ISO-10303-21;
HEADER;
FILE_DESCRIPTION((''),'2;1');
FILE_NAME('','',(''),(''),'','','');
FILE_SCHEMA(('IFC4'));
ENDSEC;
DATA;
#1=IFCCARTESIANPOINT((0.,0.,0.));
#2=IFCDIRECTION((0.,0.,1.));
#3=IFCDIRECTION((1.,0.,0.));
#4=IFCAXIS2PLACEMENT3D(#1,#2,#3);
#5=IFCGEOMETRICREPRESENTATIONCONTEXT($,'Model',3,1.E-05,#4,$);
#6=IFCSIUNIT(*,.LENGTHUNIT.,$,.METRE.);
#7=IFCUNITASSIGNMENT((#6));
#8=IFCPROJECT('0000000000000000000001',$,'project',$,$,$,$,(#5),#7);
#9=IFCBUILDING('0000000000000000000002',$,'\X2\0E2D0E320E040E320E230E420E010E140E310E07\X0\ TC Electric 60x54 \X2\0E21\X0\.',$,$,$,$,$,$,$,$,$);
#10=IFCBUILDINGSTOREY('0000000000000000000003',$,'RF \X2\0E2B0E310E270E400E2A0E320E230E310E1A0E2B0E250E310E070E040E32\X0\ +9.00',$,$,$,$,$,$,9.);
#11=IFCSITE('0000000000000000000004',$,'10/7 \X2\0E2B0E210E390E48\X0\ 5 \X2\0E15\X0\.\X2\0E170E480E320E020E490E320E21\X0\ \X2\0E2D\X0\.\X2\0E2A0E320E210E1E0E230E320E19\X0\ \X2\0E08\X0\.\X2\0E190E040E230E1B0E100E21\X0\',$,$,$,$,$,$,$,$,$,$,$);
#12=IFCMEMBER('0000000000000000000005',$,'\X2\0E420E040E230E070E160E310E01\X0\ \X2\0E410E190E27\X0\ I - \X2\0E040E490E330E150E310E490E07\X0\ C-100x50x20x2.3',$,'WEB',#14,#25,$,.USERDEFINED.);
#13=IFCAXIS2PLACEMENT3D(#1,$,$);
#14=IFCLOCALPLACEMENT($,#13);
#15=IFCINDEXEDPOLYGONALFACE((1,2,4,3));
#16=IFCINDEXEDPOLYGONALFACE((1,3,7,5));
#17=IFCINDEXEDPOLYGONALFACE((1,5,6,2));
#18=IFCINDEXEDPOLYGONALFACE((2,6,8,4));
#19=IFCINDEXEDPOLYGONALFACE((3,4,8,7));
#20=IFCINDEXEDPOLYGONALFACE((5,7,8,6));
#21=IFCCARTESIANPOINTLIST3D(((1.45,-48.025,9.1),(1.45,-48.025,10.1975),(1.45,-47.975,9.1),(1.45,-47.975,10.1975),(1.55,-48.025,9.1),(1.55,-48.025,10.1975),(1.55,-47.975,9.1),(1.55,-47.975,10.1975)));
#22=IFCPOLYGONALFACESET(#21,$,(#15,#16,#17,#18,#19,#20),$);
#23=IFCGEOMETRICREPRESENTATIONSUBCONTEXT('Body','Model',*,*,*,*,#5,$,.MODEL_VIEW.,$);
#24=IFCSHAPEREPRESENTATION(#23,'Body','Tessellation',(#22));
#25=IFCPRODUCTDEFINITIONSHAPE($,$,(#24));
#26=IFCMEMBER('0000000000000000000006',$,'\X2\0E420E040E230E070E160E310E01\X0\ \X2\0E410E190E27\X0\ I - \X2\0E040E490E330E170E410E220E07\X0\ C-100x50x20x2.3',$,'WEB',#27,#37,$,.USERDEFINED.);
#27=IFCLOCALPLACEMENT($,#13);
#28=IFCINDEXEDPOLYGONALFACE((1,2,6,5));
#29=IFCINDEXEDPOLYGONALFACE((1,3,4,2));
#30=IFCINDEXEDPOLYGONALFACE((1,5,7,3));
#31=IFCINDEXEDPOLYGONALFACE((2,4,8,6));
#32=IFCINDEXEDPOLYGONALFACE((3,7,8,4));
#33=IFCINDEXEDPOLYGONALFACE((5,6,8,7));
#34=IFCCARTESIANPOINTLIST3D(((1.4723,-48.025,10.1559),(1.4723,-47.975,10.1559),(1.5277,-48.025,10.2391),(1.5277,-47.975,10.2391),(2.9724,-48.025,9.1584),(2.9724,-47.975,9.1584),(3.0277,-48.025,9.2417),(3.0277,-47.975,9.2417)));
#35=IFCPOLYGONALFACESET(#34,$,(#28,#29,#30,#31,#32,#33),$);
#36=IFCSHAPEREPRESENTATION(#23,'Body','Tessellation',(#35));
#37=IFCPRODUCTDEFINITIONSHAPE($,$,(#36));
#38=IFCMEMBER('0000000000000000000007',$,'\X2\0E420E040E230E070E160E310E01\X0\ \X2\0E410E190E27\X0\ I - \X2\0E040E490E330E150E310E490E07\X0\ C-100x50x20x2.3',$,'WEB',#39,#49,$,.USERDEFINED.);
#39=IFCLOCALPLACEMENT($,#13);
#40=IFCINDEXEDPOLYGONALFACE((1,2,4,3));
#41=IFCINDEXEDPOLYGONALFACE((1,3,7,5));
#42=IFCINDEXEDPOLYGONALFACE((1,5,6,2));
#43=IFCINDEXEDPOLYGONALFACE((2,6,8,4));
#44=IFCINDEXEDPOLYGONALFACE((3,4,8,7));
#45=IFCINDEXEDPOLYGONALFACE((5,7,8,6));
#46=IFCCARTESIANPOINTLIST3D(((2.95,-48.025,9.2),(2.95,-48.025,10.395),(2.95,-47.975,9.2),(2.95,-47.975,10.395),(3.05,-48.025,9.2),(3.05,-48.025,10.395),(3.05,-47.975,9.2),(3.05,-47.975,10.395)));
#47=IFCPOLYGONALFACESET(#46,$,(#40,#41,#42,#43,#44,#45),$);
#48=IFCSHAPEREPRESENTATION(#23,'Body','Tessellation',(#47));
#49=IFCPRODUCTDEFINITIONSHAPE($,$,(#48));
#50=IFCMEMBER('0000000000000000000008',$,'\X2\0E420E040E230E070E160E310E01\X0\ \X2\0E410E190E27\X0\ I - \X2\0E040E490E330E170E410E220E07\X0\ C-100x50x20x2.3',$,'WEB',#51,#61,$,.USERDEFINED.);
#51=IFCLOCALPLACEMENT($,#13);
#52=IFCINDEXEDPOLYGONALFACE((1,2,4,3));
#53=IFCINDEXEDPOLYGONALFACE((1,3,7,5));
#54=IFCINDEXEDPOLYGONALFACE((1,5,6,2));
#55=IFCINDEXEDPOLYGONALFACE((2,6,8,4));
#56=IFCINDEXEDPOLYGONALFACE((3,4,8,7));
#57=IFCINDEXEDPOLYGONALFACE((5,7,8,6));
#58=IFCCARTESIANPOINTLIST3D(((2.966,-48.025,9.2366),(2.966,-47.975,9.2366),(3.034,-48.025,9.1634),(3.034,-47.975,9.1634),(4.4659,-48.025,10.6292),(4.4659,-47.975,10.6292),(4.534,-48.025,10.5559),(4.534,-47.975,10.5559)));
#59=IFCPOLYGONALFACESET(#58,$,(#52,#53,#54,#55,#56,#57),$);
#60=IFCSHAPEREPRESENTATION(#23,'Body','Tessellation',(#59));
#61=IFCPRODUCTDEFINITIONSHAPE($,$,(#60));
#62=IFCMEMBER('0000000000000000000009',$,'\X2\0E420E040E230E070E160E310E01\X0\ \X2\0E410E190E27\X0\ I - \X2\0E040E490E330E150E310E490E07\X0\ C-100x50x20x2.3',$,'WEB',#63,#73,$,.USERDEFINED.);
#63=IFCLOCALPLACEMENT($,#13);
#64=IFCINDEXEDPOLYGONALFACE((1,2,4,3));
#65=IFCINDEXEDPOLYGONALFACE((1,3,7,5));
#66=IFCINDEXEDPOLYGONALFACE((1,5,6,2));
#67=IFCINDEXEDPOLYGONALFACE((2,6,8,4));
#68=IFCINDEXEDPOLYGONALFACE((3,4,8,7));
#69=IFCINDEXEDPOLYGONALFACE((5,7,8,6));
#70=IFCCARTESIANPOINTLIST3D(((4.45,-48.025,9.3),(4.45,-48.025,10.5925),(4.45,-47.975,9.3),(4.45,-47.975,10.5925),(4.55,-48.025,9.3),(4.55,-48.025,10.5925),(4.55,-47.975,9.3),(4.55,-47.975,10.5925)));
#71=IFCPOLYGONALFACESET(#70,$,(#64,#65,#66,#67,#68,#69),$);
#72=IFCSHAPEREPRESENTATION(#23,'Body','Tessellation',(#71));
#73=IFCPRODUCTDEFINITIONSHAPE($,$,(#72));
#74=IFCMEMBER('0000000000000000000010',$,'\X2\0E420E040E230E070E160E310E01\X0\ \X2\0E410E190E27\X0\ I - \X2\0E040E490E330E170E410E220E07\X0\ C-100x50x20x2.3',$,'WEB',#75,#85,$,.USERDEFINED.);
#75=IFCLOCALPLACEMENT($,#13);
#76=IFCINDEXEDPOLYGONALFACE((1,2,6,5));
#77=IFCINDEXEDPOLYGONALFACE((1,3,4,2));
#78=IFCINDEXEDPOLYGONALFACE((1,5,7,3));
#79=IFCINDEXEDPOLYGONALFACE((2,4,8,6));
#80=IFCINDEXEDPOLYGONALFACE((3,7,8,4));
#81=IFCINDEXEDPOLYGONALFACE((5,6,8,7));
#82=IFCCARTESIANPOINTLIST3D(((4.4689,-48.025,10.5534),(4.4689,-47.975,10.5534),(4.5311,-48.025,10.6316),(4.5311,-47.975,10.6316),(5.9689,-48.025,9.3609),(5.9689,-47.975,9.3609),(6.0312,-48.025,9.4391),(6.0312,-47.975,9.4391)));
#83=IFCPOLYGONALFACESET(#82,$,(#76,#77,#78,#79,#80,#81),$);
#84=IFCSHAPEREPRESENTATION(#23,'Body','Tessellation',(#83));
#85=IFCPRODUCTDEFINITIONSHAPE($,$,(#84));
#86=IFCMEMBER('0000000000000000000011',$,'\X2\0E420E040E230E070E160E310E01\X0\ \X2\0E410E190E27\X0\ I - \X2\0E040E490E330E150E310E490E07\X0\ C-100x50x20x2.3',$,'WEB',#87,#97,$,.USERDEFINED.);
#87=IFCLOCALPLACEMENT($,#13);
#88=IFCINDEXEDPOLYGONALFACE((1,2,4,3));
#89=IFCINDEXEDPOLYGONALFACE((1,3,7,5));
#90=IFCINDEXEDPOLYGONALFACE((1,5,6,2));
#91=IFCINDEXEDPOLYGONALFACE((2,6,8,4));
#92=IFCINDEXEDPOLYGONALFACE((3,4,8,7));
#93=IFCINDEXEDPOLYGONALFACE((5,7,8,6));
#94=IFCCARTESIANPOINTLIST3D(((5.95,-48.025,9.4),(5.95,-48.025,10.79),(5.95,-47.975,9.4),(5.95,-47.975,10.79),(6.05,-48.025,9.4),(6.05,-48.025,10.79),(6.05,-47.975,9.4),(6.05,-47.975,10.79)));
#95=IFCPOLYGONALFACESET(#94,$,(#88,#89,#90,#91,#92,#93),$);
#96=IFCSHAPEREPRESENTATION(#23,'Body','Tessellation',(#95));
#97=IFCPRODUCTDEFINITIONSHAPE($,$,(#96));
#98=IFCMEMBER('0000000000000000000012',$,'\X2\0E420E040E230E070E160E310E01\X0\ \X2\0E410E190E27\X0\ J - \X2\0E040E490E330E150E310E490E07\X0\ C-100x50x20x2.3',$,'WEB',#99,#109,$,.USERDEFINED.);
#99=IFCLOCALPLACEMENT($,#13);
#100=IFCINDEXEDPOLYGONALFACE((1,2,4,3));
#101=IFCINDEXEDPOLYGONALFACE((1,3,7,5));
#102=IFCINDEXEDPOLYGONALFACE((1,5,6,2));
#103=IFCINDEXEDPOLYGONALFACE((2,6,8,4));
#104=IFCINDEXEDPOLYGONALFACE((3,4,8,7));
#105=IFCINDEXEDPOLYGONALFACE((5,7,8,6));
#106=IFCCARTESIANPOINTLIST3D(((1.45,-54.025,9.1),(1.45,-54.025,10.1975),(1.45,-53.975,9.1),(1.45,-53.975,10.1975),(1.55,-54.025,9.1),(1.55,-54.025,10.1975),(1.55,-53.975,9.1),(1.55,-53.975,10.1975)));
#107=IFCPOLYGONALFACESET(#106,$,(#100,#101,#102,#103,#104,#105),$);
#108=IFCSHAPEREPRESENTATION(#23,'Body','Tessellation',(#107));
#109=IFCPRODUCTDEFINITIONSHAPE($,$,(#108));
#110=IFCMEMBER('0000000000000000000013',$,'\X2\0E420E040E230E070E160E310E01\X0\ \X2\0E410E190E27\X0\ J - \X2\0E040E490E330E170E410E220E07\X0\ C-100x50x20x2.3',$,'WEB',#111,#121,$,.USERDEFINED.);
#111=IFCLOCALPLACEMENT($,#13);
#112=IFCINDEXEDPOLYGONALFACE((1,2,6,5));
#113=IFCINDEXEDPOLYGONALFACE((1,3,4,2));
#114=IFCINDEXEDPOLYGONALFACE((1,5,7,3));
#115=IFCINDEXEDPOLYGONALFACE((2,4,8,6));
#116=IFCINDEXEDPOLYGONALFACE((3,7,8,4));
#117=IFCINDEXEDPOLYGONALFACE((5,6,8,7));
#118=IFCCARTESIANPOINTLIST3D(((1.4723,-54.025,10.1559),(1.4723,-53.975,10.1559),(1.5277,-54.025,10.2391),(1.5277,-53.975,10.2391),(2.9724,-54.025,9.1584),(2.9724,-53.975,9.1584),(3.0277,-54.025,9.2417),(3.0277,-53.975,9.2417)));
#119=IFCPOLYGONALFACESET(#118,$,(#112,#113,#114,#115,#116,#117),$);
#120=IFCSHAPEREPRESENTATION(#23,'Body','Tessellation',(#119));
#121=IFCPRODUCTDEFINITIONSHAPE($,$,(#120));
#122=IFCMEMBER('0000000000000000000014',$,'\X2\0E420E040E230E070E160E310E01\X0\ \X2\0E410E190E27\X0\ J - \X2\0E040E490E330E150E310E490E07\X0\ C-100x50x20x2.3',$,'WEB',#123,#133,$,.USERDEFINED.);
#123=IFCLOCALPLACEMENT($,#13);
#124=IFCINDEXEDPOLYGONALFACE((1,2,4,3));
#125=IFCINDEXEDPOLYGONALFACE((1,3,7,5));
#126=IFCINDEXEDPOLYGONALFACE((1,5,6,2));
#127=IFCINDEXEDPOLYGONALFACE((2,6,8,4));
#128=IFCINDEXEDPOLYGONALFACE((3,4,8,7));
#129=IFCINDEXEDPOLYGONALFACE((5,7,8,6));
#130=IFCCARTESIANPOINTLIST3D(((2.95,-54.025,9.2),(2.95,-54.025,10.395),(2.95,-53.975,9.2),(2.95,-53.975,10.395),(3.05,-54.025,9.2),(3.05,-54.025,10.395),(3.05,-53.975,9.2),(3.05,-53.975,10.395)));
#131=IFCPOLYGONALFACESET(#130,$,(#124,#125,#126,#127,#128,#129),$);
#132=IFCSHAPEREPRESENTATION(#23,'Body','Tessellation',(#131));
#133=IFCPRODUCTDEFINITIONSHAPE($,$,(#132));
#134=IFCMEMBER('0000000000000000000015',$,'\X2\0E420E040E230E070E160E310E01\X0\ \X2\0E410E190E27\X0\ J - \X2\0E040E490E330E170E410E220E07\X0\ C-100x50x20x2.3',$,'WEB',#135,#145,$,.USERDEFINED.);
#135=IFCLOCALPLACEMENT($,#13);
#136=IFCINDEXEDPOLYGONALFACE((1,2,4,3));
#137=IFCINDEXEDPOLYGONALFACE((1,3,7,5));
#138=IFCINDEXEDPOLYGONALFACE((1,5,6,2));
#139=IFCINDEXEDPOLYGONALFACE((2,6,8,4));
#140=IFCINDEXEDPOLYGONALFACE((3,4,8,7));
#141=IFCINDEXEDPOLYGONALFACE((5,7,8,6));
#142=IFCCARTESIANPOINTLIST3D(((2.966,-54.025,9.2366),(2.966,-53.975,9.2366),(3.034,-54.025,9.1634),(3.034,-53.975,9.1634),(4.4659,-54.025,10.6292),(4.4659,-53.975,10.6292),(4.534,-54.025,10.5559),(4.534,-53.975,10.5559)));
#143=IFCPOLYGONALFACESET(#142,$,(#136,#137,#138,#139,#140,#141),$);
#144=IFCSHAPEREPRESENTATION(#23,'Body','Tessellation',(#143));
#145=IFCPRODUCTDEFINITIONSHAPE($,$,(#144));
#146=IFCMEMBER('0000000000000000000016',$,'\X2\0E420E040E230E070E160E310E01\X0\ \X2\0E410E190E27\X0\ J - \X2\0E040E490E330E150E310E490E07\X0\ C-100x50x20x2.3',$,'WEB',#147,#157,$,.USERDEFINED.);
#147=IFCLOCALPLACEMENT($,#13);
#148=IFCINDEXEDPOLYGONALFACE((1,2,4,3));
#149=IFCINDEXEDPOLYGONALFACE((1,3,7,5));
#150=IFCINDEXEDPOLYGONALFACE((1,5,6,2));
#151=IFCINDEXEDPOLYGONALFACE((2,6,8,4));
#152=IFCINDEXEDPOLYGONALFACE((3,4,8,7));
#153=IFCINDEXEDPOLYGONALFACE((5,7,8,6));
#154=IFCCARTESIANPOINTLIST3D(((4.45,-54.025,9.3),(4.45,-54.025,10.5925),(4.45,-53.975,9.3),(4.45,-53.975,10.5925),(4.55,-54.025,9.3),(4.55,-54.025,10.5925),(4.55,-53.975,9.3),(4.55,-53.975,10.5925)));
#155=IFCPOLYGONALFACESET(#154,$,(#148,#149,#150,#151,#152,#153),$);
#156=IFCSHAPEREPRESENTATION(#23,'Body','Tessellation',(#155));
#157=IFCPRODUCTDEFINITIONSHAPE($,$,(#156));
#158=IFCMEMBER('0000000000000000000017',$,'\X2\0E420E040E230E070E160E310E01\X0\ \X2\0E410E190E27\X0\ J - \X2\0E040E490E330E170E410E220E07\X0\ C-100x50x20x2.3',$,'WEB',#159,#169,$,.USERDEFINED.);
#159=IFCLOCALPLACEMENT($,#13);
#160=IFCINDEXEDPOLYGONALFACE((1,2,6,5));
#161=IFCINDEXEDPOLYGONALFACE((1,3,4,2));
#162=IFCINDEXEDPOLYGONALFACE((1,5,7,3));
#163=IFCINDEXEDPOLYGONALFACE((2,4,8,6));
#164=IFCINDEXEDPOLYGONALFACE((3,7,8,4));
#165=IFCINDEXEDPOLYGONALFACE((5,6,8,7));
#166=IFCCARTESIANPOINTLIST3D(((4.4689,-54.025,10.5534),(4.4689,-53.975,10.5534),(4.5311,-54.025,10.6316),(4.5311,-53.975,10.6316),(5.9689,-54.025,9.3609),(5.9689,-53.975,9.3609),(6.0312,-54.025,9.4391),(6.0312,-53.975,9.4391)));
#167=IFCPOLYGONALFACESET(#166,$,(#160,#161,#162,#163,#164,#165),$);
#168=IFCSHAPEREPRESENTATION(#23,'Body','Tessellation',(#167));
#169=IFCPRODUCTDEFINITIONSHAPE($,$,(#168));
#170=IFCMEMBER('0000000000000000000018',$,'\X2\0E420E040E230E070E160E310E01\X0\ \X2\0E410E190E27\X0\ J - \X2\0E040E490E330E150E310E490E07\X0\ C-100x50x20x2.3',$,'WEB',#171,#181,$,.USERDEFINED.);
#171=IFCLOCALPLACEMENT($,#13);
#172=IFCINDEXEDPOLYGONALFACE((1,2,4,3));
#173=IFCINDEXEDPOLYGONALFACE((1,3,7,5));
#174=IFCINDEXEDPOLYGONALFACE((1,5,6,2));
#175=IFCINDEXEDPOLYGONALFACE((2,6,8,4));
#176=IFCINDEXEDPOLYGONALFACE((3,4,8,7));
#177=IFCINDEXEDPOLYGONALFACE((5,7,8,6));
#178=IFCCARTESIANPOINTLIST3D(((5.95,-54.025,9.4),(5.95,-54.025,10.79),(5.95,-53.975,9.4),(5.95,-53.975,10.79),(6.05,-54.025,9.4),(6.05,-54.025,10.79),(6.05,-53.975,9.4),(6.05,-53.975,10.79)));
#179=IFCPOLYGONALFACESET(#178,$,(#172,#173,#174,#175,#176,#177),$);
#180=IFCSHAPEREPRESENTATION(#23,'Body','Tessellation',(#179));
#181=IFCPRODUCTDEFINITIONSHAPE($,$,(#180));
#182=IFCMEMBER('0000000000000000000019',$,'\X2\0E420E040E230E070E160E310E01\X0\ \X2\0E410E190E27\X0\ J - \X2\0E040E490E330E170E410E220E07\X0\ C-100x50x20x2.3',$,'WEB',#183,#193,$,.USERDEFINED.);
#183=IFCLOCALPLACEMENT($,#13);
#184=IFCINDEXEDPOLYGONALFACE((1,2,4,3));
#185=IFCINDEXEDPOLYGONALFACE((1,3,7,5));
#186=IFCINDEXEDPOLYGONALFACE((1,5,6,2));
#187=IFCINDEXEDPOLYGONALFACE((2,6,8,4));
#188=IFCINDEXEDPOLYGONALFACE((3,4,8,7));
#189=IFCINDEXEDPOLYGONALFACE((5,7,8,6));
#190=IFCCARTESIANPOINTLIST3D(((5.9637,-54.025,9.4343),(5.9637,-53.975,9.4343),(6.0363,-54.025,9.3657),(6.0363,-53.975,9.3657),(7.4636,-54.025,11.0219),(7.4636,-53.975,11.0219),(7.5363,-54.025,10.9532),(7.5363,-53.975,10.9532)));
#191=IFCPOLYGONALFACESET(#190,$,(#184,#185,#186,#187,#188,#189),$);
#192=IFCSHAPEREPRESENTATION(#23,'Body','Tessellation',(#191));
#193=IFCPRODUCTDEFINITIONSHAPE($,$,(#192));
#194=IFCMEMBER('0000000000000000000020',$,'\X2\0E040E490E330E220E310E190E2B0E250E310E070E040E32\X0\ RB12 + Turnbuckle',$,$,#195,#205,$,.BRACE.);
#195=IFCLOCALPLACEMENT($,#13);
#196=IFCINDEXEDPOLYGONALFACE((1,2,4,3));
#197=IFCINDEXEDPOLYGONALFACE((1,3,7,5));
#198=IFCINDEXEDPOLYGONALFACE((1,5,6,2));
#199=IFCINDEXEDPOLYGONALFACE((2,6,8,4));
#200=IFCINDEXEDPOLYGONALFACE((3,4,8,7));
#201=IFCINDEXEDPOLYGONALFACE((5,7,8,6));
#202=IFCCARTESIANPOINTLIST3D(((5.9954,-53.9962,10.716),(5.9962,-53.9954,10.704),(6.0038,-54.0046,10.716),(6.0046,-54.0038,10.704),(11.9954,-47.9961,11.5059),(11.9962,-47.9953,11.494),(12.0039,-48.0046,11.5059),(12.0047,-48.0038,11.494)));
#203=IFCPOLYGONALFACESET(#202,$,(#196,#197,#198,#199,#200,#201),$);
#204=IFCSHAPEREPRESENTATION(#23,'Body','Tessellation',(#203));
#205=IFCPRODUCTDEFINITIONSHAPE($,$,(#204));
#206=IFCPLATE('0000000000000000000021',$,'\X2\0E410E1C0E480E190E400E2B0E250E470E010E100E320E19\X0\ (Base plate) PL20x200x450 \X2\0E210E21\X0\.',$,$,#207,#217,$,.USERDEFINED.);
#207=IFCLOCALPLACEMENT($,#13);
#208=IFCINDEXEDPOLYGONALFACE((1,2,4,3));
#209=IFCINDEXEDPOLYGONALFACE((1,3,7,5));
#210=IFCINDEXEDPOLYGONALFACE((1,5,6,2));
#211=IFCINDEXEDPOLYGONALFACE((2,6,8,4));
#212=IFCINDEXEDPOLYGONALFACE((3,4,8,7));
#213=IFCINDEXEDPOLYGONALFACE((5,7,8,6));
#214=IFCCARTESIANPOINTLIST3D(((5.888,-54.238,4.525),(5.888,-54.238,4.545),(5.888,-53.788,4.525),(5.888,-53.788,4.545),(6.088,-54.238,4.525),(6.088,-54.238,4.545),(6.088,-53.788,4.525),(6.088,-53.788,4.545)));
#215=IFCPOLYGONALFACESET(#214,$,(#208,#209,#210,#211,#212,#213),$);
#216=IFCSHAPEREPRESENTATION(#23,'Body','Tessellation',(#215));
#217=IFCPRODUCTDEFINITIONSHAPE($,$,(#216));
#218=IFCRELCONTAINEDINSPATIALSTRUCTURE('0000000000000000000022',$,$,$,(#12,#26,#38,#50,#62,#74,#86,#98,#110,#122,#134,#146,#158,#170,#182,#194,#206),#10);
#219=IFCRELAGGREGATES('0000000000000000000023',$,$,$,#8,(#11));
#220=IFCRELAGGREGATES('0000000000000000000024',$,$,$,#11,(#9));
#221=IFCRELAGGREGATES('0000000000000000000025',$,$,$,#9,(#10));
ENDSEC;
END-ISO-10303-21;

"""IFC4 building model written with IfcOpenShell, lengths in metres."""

from ifc_helpers import new_model, si_unit, frame, origin, origin_with_axes, origin_2d, place, context, subcontext, project, spatial, rectangle, extrude, element, save


model = new_model("IFC4")

# Units and contexts
model_context = context("Model", 3, precision=1e-05, world=origin_with_axes())
body_context = subcontext(model_context, "Body", "Model", "MODEL_VIEW")
ifc_project = project(units=[si_unit("LENGTHUNIT", "METRE")], contexts=[model_context])

# Site, building, storey
site = spatial("IfcSite", under=ifc_project, Name="10/7 หมู่ 5 ต.ท่าข้าม อ.สามพราน จ.นครปฐม")
building = spatial("IfcBuilding", under=site, Name="อาคารโกดัง TC Electric 60x54 ม.")
storey = spatial("IfcBuildingStorey", under=building, Name="RF หัวเสารับหลังคา +9.00", Elevation=9.0)

# Members
member_1_placement = place(None, frame((1.5, -48.0, 9.1), z_axis=(0.0, 0.0, 1.0), x_axis=(0.0, 1.0, 0.0)))
element("IfcMember", 1, at=member_1_placement, inside=storey, Name="โครงถัก แนว I - ค้ำตั้ง C-100x50x20x2.3", ObjectType="WEB", PredefinedType="USERDEFINED", context=body_context, shape_type="SweptSolid", body=[
    extrude(rectangle(XDim=0.05, YDim=0.1, at=origin_2d()), origin(), (0.0, 0.0, 1.0), 1.0975),
])
member_2_placement = place(None, frame((1.5, -48.0, 10.1975), z_axis=(0.8327, 0.0, -0.5537), x_axis=(0.0, -1.0, 0.0)))
element("IfcMember", 2, at=member_2_placement, inside=storey, Name="โครงถัก แนว I - ค้ำทแยง C-100x50x20x2.3", ObjectType="WEB", PredefinedType="USERDEFINED", context=body_context, shape_type="SweptSolid", body=[
    extrude(rectangle(XDim=0.05, YDim=0.1, at=origin_2d()), origin(), (0.0, 0.0, 1.0), 1.8014),
])
member_3_placement = place(None, frame((3.0, -48.0, 9.2), z_axis=(0.0, 0.0, 1.0), x_axis=(0.0, 1.0, 0.0)))
element("IfcMember", 3, at=member_3_placement, inside=storey, Name="โครงถัก แนว I - ค้ำตั้ง C-100x50x20x2.3", ObjectType="WEB", PredefinedType="USERDEFINED", context=body_context, shape_type="SweptSolid", body=[
    extrude(rectangle(XDim=0.05, YDim=0.1, at=origin_2d()), origin(), (0.0, 0.0, 1.0), 1.195),
])
member_4_placement = place(None, frame((3.0, -48.0, 9.2), z_axis=(0.7329, 0.0, 0.6804), x_axis=(0.0, -1.0, 0.0)))
element("IfcMember", 4, at=member_4_placement, inside=storey, Name="โครงถัก แนว I - ค้ำทแยง C-100x50x20x2.3", ObjectType="WEB", PredefinedType="USERDEFINED", context=body_context, shape_type="SweptSolid", body=[
    extrude(rectangle(XDim=0.05, YDim=0.1, at=origin_2d()), origin(), (0.0, 0.0, 1.0), 2.0467),
])
member_5_placement = place(None, frame((4.5, -48.0, 9.3), z_axis=(0.0, 0.0, 1.0), x_axis=(0.0, 1.0, 0.0)))
element("IfcMember", 5, at=member_5_placement, inside=storey, Name="โครงถัก แนว I - ค้ำตั้ง C-100x50x20x2.3", ObjectType="WEB", PredefinedType="USERDEFINED", context=body_context, shape_type="SweptSolid", body=[
    extrude(rectangle(XDim=0.05, YDim=0.1, at=origin_2d()), origin(), (0.0, 0.0, 1.0), 1.2925),
])
member_6_placement = place(None, frame((4.5, -48.0, 10.5925), z_axis=(0.7828, 0.0, -0.6223), x_axis=(0.0, -1.0, 0.0)))
element("IfcMember", 6, at=member_6_placement, inside=storey, Name="โครงถัก แนว I - ค้ำทแยง C-100x50x20x2.3", ObjectType="WEB", PredefinedType="USERDEFINED", context=body_context, shape_type="SweptSolid", body=[
    extrude(rectangle(XDim=0.05, YDim=0.1, at=origin_2d()), origin(), (0.0, 0.0, 1.0), 1.9163),
])
member_7_placement = place(None, frame((6.0, -48.0, 9.4), z_axis=(0.0, 0.0, 1.0), x_axis=(0.0, 1.0, 0.0)))
element("IfcMember", 7, at=member_7_placement, inside=storey, Name="โครงถัก แนว I - ค้ำตั้ง C-100x50x20x2.3", ObjectType="WEB", PredefinedType="USERDEFINED", context=body_context, shape_type="SweptSolid", body=[
    extrude(rectangle(XDim=0.05, YDim=0.1, at=origin_2d()), origin(), (0.0, 0.0, 1.0), 1.39),
])
member_8_placement = place(None, frame((1.5, -54.0, 9.1), z_axis=(0.0, 0.0, 1.0), x_axis=(0.0, 1.0, 0.0)))
element("IfcMember", 8, at=member_8_placement, inside=storey, Name="โครงถัก แนว J - ค้ำตั้ง C-100x50x20x2.3", ObjectType="WEB", PredefinedType="USERDEFINED", context=body_context, shape_type="SweptSolid", body=[
    extrude(rectangle(XDim=0.05, YDim=0.1, at=origin_2d()), origin(), (0.0, 0.0, 1.0), 1.0975),
])
member_9_placement = place(None, frame((1.5, -54.0, 10.1975), z_axis=(0.8327, 0.0, -0.5537), x_axis=(0.0, -1.0, 0.0)))
element("IfcMember", 9, at=member_9_placement, inside=storey, Name="โครงถัก แนว J - ค้ำทแยง C-100x50x20x2.3", ObjectType="WEB", PredefinedType="USERDEFINED", context=body_context, shape_type="SweptSolid", body=[
    extrude(rectangle(XDim=0.05, YDim=0.1, at=origin_2d()), origin(), (0.0, 0.0, 1.0), 1.8014),
])
member_10_placement = place(None, frame((3.0, -54.0, 9.2), z_axis=(0.0, 0.0, 1.0), x_axis=(0.0, 1.0, 0.0)))
element("IfcMember", 10, at=member_10_placement, inside=storey, Name="โครงถัก แนว J - ค้ำตั้ง C-100x50x20x2.3", ObjectType="WEB", PredefinedType="USERDEFINED", context=body_context, shape_type="SweptSolid", body=[
    extrude(rectangle(XDim=0.05, YDim=0.1, at=origin_2d()), origin(), (0.0, 0.0, 1.0), 1.195),
])
member_11_placement = place(None, frame((3.0, -54.0, 9.2), z_axis=(0.7329, 0.0, 0.6804), x_axis=(0.0, -1.0, 0.0)))
element("IfcMember", 11, at=member_11_placement, inside=storey, Name="โครงถัก แนว J - ค้ำทแยง C-100x50x20x2.3", ObjectType="WEB", PredefinedType="USERDEFINED", context=body_context, shape_type="SweptSolid", body=[
    extrude(rectangle(XDim=0.05, YDim=0.1, at=origin_2d()), origin(), (0.0, 0.0, 1.0), 2.0467),
])
member_12_placement = place(None, frame((4.5, -54.0, 9.3), z_axis=(0.0, 0.0, 1.0), x_axis=(0.0, 1.0, 0.0)))
element("IfcMember", 12, at=member_12_placement, inside=storey, Name="โครงถัก แนว J - ค้ำตั้ง C-100x50x20x2.3", ObjectType="WEB", PredefinedType="USERDEFINED", context=body_context, shape_type="SweptSolid", body=[
    extrude(rectangle(XDim=0.05, YDim=0.1, at=origin_2d()), origin(), (0.0, 0.0, 1.0), 1.2925),
])
member_13_placement = place(None, frame((4.5, -54.0, 10.5925), z_axis=(0.7828, 0.0, -0.6223), x_axis=(0.0, -1.0, 0.0)))
element("IfcMember", 13, at=member_13_placement, inside=storey, Name="โครงถัก แนว J - ค้ำทแยง C-100x50x20x2.3", ObjectType="WEB", PredefinedType="USERDEFINED", context=body_context, shape_type="SweptSolid", body=[
    extrude(rectangle(XDim=0.05, YDim=0.1, at=origin_2d()), origin(), (0.0, 0.0, 1.0), 1.9163),
])
member_14_placement = place(None, frame((6.0, -54.0, 9.4), z_axis=(0.0, 0.0, 1.0), x_axis=(0.0, 1.0, 0.0)))
element("IfcMember", 14, at=member_14_placement, inside=storey, Name="โครงถัก แนว J - ค้ำตั้ง C-100x50x20x2.3", ObjectType="WEB", PredefinedType="USERDEFINED", context=body_context, shape_type="SweptSolid", body=[
    extrude(rectangle(XDim=0.05, YDim=0.1, at=origin_2d()), origin(), (0.0, 0.0, 1.0), 1.39),
])
member_15_placement = place(None, frame((6.0, -54.0, 9.4), z_axis=(0.6868, 0.0, 0.7269), x_axis=(0.0, -1.0, 0.0)))
element("IfcMember", 15, at=member_15_placement, inside=storey, Name="โครงถัก แนว J - ค้ำทแยง C-100x50x20x2.3", ObjectType="WEB", PredefinedType="USERDEFINED", context=body_context, shape_type="SweptSolid", body=[
    extrude(rectangle(XDim=0.05, YDim=0.1, at=origin_2d()), origin(), (0.0, 0.0, 1.0), 2.1841),
])
member_16_placement = place(None, frame((6.0, -54.0, 10.71), z_axis=(0.7041, 0.7041, 0.0927), x_axis=(0.7071, -0.7071, 0.0)))
element("IfcMember", 16, at=member_16_placement, inside=storey, Name="ค้ำยันหลังคา RB12 + Turnbuckle", PredefinedType="BRACE", context=body_context, shape_type="SweptSolid", body=[
    extrude(rectangle(XDim=0.012, YDim=0.012, at=origin_2d()), origin(), (0.0, 0.0, 1.0), 8.522),
])

# Plate
for number, where, z_axis, x_axis, name in (
    (17, (5.988, -54.013, 4.525), (0.0, 0.0, 1.0), (1.0, 0.0, 0.0), "แผ่นเหล็กฐาน (Base plate) PL20x200x450 มม."),
):
    element("IfcPlate", number, at=place(None, frame(where, z_axis=z_axis, x_axis=x_axis)), inside=storey, Name=name, PredefinedType="USERDEFINED", context=body_context, shape_type="SweptSolid", body=[
        extrude(rectangle(XDim=0.2, YDim=0.45, at=origin_2d()), origin(), (0.0, 0.0, 1.0), 0.02),
    ])

save(model, "model.ifc")
